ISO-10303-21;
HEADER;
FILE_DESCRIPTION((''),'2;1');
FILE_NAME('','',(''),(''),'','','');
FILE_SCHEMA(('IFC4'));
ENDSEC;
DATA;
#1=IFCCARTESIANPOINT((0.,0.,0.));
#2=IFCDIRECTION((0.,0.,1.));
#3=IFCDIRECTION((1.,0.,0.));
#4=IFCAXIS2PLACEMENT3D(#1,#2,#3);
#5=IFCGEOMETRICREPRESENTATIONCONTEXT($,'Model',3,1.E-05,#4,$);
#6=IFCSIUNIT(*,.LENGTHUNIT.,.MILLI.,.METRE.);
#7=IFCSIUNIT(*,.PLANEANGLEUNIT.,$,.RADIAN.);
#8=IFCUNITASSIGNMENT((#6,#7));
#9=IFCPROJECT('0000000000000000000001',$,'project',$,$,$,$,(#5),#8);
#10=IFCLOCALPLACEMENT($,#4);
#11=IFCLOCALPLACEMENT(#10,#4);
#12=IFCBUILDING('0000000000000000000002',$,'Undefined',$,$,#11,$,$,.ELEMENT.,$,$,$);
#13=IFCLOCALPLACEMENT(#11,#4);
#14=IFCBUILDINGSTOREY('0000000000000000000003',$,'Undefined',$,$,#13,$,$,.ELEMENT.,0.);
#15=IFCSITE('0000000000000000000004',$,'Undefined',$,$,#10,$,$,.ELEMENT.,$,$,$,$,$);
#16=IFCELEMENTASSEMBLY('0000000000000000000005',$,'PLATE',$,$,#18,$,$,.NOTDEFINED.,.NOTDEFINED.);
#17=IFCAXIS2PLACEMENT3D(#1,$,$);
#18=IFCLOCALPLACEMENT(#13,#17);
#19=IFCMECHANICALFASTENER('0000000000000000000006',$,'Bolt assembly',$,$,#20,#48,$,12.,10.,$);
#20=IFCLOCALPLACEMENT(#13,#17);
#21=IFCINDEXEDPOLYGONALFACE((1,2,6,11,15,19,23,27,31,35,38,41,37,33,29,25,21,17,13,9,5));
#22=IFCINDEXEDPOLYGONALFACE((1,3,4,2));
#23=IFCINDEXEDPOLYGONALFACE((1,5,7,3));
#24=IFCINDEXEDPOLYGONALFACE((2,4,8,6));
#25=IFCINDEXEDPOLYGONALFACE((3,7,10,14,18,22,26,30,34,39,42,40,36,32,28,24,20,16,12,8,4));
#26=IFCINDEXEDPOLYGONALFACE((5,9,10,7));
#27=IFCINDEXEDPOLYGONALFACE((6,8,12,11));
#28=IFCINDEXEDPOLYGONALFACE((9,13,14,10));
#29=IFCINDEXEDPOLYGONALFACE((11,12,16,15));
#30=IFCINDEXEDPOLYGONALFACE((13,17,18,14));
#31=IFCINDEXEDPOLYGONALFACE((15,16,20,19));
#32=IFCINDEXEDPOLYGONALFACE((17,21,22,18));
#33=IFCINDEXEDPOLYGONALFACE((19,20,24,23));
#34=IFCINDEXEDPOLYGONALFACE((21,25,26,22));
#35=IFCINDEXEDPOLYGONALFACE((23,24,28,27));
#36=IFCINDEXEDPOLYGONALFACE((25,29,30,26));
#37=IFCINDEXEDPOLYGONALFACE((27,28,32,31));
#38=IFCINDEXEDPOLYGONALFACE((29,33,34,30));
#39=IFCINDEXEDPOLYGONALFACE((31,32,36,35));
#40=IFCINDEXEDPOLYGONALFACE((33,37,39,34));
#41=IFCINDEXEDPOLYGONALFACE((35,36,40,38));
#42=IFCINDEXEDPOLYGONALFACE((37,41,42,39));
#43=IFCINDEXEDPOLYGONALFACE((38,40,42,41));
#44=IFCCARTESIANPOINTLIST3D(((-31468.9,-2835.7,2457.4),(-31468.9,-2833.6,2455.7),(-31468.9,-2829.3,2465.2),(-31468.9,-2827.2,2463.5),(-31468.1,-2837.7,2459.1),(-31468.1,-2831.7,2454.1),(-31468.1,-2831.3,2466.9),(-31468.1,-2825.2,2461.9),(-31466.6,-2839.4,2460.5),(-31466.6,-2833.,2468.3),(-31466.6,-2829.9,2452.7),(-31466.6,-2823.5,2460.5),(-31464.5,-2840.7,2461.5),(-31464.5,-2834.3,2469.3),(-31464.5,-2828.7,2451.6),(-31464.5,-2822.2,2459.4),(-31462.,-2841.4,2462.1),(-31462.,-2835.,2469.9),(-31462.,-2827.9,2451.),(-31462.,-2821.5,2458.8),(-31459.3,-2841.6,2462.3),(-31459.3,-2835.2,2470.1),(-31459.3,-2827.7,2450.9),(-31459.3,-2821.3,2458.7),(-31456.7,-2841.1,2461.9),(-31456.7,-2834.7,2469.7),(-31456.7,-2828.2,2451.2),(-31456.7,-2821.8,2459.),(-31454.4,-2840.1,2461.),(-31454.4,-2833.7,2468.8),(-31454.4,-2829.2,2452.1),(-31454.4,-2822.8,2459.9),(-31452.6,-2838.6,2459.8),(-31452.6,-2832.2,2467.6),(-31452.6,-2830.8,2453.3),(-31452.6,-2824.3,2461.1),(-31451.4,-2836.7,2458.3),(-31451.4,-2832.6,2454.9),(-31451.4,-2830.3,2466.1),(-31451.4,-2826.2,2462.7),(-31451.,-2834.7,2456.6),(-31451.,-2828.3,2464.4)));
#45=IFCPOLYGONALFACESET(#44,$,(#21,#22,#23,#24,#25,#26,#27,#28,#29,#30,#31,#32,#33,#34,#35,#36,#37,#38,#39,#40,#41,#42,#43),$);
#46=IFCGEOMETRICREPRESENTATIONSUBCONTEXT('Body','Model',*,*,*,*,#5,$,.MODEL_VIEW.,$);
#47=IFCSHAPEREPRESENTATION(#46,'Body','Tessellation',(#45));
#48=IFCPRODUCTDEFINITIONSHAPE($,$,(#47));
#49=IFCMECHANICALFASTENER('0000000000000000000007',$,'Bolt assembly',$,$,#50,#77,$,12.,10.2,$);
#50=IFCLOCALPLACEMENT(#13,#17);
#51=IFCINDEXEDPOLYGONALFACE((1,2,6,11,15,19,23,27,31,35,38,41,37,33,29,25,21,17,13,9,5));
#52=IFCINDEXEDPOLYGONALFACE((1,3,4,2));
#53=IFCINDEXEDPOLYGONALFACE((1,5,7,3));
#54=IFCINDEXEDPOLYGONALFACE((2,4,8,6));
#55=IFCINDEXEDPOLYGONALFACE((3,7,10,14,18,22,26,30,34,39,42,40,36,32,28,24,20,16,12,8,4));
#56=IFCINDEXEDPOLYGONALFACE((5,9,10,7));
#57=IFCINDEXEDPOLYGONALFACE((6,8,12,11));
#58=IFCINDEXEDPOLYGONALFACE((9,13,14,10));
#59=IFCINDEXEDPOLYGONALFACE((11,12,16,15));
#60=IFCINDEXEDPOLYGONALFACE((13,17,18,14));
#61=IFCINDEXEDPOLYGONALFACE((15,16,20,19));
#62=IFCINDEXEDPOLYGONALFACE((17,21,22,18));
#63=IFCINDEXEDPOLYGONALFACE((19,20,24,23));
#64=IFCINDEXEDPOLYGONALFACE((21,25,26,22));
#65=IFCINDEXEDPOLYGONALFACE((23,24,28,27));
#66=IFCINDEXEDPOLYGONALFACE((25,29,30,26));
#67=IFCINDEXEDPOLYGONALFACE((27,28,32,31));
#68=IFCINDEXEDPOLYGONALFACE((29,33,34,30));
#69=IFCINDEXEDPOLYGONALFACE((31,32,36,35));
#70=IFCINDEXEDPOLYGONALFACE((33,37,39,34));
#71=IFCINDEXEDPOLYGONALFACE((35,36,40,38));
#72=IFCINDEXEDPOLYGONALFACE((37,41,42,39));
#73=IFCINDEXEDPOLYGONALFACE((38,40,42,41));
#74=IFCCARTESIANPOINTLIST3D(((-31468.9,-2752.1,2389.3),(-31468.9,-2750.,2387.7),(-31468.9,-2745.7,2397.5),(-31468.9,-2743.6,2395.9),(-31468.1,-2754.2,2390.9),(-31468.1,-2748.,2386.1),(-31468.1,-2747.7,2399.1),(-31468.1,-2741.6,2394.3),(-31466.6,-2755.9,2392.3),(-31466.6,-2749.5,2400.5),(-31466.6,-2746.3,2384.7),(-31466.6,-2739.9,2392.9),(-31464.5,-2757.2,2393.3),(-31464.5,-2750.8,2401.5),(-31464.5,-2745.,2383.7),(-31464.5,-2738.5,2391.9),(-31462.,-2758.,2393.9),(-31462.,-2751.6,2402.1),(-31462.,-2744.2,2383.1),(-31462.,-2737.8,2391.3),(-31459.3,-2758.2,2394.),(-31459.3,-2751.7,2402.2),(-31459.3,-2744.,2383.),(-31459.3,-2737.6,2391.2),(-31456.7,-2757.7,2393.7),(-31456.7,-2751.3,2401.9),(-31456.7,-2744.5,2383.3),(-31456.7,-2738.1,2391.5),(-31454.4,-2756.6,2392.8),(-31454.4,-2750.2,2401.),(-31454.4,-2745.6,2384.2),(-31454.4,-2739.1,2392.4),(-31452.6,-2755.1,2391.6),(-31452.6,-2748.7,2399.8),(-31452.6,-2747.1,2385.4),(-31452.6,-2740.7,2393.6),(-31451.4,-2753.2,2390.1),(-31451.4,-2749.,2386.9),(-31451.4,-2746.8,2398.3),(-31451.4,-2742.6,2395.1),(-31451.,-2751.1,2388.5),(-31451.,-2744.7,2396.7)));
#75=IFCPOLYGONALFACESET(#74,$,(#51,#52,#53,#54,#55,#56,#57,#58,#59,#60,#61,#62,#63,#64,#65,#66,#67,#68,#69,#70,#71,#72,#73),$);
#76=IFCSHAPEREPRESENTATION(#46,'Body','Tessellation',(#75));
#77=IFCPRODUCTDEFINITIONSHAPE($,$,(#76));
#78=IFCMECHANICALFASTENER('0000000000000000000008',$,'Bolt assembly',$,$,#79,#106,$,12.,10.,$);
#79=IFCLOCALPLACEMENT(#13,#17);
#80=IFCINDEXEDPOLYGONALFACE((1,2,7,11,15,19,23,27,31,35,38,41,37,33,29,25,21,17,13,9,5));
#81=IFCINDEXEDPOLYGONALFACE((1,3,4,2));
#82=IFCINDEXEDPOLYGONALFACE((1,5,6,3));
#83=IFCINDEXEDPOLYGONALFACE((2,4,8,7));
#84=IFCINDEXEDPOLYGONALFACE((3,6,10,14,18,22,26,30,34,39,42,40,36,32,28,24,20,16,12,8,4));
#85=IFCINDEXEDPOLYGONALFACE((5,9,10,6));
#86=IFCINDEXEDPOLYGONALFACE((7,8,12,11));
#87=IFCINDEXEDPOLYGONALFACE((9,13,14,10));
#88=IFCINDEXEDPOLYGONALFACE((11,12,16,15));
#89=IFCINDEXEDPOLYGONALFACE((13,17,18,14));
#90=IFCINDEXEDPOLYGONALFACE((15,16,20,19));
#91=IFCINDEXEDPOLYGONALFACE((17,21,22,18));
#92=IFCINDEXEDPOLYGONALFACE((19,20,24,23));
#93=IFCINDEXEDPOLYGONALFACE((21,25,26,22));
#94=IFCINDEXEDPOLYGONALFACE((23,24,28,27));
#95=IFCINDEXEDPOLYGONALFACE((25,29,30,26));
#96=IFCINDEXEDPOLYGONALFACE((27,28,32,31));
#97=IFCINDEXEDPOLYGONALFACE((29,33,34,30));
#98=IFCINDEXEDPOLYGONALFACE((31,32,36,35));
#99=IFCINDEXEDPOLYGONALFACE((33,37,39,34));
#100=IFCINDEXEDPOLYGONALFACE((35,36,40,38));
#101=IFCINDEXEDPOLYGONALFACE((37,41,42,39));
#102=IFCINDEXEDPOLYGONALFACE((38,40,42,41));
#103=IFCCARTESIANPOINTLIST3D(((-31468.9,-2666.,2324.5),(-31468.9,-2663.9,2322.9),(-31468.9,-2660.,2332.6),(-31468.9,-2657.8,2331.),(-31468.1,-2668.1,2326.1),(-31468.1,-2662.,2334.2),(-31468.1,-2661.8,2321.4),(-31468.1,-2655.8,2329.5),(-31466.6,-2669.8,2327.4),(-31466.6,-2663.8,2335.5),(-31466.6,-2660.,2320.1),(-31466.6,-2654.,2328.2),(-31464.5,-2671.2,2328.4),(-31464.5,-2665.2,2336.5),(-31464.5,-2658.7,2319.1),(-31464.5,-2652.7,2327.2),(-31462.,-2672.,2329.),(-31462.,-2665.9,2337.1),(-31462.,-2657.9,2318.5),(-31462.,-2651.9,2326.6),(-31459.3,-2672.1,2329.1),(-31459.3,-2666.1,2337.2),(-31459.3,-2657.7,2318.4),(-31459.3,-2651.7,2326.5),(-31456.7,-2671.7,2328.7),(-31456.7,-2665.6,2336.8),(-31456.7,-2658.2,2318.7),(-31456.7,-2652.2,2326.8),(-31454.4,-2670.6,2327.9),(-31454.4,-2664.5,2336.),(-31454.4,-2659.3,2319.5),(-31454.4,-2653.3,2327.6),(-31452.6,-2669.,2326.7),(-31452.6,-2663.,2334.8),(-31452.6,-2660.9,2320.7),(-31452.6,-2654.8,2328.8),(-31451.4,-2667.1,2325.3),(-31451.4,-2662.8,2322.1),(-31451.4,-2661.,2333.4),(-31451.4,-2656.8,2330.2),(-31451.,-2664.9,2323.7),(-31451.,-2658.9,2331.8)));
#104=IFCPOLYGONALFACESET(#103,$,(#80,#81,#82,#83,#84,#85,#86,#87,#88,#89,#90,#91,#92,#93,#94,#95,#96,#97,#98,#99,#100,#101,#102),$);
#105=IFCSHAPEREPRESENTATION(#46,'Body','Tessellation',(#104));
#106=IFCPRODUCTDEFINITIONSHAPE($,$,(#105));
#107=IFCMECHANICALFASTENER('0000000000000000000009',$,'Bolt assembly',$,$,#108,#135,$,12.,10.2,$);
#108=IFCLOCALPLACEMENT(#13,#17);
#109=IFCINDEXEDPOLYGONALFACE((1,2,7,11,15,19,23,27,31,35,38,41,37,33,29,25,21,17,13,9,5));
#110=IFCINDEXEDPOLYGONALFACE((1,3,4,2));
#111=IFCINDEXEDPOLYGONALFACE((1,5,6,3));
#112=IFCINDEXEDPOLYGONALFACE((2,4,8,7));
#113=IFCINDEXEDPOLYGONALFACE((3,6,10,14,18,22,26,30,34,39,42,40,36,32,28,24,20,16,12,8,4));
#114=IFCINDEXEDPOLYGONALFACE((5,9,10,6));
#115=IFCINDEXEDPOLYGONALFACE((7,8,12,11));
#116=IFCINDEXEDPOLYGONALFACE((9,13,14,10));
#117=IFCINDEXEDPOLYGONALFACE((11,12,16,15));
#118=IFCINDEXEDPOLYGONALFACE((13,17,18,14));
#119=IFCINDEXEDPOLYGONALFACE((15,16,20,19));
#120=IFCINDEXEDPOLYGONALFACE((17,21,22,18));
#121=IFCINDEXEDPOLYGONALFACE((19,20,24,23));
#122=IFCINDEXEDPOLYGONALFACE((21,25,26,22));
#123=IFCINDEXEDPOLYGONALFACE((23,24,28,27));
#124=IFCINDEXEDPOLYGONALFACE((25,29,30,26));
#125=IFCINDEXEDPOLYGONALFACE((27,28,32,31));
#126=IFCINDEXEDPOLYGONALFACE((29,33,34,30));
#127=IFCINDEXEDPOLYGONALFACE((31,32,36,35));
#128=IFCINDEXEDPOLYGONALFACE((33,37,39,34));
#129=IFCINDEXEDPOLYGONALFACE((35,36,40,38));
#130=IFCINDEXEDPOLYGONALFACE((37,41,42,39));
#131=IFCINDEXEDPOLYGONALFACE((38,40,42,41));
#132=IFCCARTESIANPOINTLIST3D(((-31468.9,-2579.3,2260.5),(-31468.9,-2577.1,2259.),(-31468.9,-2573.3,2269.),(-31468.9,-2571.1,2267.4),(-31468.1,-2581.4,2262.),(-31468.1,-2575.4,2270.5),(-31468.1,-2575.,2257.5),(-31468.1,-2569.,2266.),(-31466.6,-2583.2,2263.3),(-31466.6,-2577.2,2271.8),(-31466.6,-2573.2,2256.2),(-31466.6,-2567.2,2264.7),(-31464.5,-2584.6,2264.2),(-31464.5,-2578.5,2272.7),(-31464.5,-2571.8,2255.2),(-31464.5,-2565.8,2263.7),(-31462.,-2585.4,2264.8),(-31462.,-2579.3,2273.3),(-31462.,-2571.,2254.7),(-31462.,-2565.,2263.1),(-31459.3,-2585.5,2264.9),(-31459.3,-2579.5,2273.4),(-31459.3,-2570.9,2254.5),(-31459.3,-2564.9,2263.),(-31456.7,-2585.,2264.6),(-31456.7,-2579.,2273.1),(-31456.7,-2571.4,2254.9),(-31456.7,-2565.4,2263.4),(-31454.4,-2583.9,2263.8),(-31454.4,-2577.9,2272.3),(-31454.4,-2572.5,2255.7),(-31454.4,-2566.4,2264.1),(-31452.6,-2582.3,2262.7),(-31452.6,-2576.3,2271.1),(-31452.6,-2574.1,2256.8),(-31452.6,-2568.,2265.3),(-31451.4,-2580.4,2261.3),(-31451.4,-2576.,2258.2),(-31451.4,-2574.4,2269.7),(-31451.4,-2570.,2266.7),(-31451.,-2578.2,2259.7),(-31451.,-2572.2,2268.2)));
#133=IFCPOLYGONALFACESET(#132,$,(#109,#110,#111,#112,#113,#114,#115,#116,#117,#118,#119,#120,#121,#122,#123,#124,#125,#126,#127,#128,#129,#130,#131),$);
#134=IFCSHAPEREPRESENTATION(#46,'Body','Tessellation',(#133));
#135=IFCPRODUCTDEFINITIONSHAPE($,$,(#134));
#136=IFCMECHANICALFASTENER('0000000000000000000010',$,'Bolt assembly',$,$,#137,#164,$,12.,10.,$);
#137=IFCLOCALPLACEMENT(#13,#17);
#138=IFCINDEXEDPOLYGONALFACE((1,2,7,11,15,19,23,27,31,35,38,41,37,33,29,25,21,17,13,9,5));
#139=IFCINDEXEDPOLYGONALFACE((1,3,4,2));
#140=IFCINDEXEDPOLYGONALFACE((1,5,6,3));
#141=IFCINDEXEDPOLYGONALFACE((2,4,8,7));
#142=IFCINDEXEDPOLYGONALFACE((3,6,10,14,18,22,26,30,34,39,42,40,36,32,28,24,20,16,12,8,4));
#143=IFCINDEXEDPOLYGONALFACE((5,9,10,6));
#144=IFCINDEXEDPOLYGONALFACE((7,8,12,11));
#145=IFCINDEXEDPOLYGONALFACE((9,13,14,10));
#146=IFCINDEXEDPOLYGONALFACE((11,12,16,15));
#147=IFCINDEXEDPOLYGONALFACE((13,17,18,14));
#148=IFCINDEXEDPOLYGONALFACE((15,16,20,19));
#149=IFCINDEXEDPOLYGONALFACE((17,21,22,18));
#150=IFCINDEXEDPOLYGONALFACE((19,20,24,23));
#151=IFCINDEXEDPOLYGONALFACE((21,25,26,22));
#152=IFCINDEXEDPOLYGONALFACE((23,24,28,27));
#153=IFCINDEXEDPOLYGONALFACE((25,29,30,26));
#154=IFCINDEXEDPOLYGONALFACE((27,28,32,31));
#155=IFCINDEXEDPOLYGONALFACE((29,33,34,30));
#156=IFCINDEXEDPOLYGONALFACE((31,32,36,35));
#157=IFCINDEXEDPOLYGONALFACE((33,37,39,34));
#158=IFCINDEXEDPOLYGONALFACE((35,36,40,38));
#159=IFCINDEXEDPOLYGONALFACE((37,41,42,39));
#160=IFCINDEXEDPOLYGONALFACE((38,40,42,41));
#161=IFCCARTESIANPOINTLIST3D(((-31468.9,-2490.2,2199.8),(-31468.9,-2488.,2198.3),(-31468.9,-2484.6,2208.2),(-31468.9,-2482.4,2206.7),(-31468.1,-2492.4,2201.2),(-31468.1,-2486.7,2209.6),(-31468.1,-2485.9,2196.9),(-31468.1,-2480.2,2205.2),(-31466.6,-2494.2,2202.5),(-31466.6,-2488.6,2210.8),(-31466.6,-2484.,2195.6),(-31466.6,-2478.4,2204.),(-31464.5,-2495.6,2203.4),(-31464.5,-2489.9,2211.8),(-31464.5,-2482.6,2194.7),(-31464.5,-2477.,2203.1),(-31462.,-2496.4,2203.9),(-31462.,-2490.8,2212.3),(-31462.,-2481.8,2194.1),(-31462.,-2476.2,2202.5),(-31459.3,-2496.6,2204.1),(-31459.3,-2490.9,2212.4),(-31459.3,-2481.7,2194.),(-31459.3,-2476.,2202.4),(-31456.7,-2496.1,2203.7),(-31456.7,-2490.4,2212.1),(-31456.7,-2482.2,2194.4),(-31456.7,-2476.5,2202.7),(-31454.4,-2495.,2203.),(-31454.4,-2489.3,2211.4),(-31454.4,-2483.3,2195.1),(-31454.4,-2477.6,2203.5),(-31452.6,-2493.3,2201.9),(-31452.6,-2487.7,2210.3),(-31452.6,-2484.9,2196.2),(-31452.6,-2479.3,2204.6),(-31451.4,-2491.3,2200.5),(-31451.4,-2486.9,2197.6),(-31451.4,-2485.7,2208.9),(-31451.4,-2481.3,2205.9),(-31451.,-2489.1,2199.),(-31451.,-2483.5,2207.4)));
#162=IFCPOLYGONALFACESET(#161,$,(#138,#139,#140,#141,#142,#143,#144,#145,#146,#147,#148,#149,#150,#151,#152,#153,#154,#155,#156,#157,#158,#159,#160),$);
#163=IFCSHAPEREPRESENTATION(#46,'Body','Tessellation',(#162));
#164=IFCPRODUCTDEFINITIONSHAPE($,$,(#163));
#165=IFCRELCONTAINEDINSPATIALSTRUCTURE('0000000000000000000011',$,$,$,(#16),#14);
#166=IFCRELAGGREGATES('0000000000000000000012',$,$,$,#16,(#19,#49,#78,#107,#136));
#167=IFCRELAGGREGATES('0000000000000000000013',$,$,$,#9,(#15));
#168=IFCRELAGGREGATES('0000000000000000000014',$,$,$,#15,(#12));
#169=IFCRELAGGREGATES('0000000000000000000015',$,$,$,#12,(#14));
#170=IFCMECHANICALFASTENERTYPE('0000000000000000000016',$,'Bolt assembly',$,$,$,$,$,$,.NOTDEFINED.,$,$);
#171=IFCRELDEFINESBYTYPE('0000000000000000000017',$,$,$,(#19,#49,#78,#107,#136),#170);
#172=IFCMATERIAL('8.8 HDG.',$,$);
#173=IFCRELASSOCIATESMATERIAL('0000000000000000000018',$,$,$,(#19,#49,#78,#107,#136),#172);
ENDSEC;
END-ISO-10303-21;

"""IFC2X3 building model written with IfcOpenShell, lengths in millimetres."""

from ifc_helpers import new_model, si_unit, frame, origin_with_axes, origin_2d_with_axis, place, context, subcontext, project, spatial, circle, extrude, source, transform, mapped, material, type_object, element, aggregate, save


model = new_model("IFC2X3")

# Units and contexts
model_context = context("Model", 3, precision=1e-05, world=origin_with_axes())
body_context = subcontext(model_context, "Body", "Model", "MODEL_VIEW")
ifc_project = project(units=[si_unit("LENGTHUNIT", "METRE", prefix="MILLI"), si_unit("PLANEANGLEUNIT", "RADIAN")], contexts=[model_context])

# Site, building, storey
site_placement = place(None, origin_with_axes())
site = spatial("IfcSite", under=ifc_project, at=site_placement, Name="Undefined", CompositionType="ELEMENT")
building_placement = place(site_placement, origin_with_axes())
building = spatial("IfcBuilding", under=site, at=building_placement, Name="Undefined", CompositionType="ELEMENT")
storey_placement = place(building_placement, origin_with_axes())
storey = spatial("IfcBuildingStorey", under=building, at=storey_placement, Name="Undefined", CompositionType="ELEMENT", Elevation=0.0)

# Element assembly, mechanical fasteners
assembly_placement = place(storey_placement, origin_with_axes())
assembly = element("IfcElementAssembly", 1, at=assembly_placement, inside=storey, Name="PLATE", AssemblyPlace="NOTDEFINED", PredefinedType="NOTDEFINED")
ifc_material_1 = material(Name="8.8 HDG.")
mechanical_fastener_type = type_object("IfcMechanicalFastenerType", Name="Bolt assembly")
shared_shape_1 = source(origin_with_axes(), body_context, "Body", "SweptSolid", [
    extrude(circle(Radius=9.0, at=origin_2d_with_axis()), frame((0.0, 0.8, 0.0), z_axis=(0.0, 1.0, 0.0), x_axis=(1.0, 0.0, 0.0)), (0.0, 0.0, 1.0), 10.1),
])
mechanical_fastener_1_placement = place(assembly_placement, frame((-31460.0, -2835.2, 2455.9), z_axis=(0.000001, -0.772051, 0.63556), x_axis=(1.0, 0.000001, -0.000001)))
mechanical_fastener_1 = element("IfcMechanicalFastener", 2, at=mechanical_fastener_1_placement, type_object=mechanical_fastener_type, material=ifc_material_1, Name="Bolt assembly", NominalDiameter=12.0, NominalLength=10.0, context=body_context, shape_type="MappedRepresentation", body=[
    mapped(shared_shape_1, transform((0.0, 0.0, 0.0))),
])
shared_shape_2 = source(origin_with_axes(), body_context, "Body", "SweptSolid", [
    extrude(circle(Radius=9.0, at=origin_2d_with_axis()), frame((0.0, 0.1, 0.0), z_axis=(0.0, 1.0, 0.0), x_axis=(1.0, 0.0, 0.0)), (0.0, 0.0, 1.0), 10.4),
])
mechanical_fastener_2_placement = place(assembly_placement, frame((-31460.0, -2751.2, 2388.4), z_axis=(0.000001, -0.787183, 0.616719), x_axis=(1.0, 0.000001, -0.000001)))
mechanical_fastener_2 = element("IfcMechanicalFastener", 3, at=mechanical_fastener_2_placement, type_object=mechanical_fastener_type, material=ifc_material_1, Name="Bolt assembly", NominalDiameter=12.0, NominalLength=10.2, context=body_context, shape_type="MappedRepresentation", body=[
    mapped(shared_shape_2, transform((0.0, 0.0, 0.0))),
])
shared_shape_3 = source(origin_with_axes(), body_context, "Body", "SweptSolid", [
    extrude(circle(Radius=9.0, at=origin_2d_with_axis()), frame((0.0, 0.9, 0.0), z_axis=(0.0, 1.0, 0.0), x_axis=(1.0, 0.0, 0.0)), (0.0, 0.0, 1.0), 10.1),
])
mechanical_fastener_3_placement = place(assembly_placement, frame((-31460.0, -2665.5, 2323.0), z_axis=(0.000001, -0.801856, 0.597518), x_axis=(1.0, 0.000001, -0.000001)))
mechanical_fastener_3 = element("IfcMechanicalFastener", 4, at=mechanical_fastener_3_placement, type_object=mechanical_fastener_type, material=ifc_material_1, Name="Bolt assembly", NominalDiameter=12.0, NominalLength=10.0, context=body_context, shape_type="MappedRepresentation", body=[
    mapped(shared_shape_3, transform((0.0, 0.0, 0.0))),
])
shared_shape_4 = source(origin_with_axes(), body_context, "Body", "SweptSolid", [
    extrude(circle(Radius=9.0, at=origin_2d_with_axis()), frame((0.0, 0.2, 0.0), z_axis=(0.0, 1.0, 0.0), x_axis=(1.0, 0.0, 0.0)), (0.0, 0.0, 1.0), 10.4),
])
mechanical_fastener_4_placement = place(assembly_placement, frame((-31460.0, -2578.3, 2259.6), z_axis=(0.000001, -0.81606, 0.577967), x_axis=(1.0, 0.000001, -0.000001)))
mechanical_fastener_4 = element("IfcMechanicalFastener", 5, at=mechanical_fastener_4_placement, type_object=mechanical_fastener_type, material=ifc_material_1, Name="Bolt assembly", NominalDiameter=12.0, NominalLength=10.2, context=body_context, shape_type="MappedRepresentation", body=[
    mapped(shared_shape_4, transform((0.0, 0.0, 0.0))),
])
shared_shape_5 = source(origin_with_axes(), body_context, "Body", "SweptSolid", [
    extrude(circle(Radius=9.0, at=origin_2d_with_axis()), frame((0.0, 0.8, 0.0), z_axis=(0.0, 1.0, 0.0), x_axis=(1.0, 0.0, 0.0)), (0.0, 0.0, 1.0), 10.1),
])
mechanical_fastener_5_placement = place(assembly_placement, frame((-31460.0, -2489.6, 2198.4), z_axis=(0.000001, -0.829788, 0.558079), x_axis=(1.0, 0.000001, -0.000001)))
mechanical_fastener_5 = element("IfcMechanicalFastener", 6, at=mechanical_fastener_5_placement, type_object=mechanical_fastener_type, material=ifc_material_1, Name="Bolt assembly", NominalDiameter=12.0, NominalLength=10.0, context=body_context, shape_type="MappedRepresentation", body=[
    mapped(shared_shape_5, transform((0.0, 0.0, 0.0))),
])
aggregate(assembly, [mechanical_fastener_1, mechanical_fastener_2, mechanical_fastener_3, mechanical_fastener_4, mechanical_fastener_5])

save(model, "model.ifc")
